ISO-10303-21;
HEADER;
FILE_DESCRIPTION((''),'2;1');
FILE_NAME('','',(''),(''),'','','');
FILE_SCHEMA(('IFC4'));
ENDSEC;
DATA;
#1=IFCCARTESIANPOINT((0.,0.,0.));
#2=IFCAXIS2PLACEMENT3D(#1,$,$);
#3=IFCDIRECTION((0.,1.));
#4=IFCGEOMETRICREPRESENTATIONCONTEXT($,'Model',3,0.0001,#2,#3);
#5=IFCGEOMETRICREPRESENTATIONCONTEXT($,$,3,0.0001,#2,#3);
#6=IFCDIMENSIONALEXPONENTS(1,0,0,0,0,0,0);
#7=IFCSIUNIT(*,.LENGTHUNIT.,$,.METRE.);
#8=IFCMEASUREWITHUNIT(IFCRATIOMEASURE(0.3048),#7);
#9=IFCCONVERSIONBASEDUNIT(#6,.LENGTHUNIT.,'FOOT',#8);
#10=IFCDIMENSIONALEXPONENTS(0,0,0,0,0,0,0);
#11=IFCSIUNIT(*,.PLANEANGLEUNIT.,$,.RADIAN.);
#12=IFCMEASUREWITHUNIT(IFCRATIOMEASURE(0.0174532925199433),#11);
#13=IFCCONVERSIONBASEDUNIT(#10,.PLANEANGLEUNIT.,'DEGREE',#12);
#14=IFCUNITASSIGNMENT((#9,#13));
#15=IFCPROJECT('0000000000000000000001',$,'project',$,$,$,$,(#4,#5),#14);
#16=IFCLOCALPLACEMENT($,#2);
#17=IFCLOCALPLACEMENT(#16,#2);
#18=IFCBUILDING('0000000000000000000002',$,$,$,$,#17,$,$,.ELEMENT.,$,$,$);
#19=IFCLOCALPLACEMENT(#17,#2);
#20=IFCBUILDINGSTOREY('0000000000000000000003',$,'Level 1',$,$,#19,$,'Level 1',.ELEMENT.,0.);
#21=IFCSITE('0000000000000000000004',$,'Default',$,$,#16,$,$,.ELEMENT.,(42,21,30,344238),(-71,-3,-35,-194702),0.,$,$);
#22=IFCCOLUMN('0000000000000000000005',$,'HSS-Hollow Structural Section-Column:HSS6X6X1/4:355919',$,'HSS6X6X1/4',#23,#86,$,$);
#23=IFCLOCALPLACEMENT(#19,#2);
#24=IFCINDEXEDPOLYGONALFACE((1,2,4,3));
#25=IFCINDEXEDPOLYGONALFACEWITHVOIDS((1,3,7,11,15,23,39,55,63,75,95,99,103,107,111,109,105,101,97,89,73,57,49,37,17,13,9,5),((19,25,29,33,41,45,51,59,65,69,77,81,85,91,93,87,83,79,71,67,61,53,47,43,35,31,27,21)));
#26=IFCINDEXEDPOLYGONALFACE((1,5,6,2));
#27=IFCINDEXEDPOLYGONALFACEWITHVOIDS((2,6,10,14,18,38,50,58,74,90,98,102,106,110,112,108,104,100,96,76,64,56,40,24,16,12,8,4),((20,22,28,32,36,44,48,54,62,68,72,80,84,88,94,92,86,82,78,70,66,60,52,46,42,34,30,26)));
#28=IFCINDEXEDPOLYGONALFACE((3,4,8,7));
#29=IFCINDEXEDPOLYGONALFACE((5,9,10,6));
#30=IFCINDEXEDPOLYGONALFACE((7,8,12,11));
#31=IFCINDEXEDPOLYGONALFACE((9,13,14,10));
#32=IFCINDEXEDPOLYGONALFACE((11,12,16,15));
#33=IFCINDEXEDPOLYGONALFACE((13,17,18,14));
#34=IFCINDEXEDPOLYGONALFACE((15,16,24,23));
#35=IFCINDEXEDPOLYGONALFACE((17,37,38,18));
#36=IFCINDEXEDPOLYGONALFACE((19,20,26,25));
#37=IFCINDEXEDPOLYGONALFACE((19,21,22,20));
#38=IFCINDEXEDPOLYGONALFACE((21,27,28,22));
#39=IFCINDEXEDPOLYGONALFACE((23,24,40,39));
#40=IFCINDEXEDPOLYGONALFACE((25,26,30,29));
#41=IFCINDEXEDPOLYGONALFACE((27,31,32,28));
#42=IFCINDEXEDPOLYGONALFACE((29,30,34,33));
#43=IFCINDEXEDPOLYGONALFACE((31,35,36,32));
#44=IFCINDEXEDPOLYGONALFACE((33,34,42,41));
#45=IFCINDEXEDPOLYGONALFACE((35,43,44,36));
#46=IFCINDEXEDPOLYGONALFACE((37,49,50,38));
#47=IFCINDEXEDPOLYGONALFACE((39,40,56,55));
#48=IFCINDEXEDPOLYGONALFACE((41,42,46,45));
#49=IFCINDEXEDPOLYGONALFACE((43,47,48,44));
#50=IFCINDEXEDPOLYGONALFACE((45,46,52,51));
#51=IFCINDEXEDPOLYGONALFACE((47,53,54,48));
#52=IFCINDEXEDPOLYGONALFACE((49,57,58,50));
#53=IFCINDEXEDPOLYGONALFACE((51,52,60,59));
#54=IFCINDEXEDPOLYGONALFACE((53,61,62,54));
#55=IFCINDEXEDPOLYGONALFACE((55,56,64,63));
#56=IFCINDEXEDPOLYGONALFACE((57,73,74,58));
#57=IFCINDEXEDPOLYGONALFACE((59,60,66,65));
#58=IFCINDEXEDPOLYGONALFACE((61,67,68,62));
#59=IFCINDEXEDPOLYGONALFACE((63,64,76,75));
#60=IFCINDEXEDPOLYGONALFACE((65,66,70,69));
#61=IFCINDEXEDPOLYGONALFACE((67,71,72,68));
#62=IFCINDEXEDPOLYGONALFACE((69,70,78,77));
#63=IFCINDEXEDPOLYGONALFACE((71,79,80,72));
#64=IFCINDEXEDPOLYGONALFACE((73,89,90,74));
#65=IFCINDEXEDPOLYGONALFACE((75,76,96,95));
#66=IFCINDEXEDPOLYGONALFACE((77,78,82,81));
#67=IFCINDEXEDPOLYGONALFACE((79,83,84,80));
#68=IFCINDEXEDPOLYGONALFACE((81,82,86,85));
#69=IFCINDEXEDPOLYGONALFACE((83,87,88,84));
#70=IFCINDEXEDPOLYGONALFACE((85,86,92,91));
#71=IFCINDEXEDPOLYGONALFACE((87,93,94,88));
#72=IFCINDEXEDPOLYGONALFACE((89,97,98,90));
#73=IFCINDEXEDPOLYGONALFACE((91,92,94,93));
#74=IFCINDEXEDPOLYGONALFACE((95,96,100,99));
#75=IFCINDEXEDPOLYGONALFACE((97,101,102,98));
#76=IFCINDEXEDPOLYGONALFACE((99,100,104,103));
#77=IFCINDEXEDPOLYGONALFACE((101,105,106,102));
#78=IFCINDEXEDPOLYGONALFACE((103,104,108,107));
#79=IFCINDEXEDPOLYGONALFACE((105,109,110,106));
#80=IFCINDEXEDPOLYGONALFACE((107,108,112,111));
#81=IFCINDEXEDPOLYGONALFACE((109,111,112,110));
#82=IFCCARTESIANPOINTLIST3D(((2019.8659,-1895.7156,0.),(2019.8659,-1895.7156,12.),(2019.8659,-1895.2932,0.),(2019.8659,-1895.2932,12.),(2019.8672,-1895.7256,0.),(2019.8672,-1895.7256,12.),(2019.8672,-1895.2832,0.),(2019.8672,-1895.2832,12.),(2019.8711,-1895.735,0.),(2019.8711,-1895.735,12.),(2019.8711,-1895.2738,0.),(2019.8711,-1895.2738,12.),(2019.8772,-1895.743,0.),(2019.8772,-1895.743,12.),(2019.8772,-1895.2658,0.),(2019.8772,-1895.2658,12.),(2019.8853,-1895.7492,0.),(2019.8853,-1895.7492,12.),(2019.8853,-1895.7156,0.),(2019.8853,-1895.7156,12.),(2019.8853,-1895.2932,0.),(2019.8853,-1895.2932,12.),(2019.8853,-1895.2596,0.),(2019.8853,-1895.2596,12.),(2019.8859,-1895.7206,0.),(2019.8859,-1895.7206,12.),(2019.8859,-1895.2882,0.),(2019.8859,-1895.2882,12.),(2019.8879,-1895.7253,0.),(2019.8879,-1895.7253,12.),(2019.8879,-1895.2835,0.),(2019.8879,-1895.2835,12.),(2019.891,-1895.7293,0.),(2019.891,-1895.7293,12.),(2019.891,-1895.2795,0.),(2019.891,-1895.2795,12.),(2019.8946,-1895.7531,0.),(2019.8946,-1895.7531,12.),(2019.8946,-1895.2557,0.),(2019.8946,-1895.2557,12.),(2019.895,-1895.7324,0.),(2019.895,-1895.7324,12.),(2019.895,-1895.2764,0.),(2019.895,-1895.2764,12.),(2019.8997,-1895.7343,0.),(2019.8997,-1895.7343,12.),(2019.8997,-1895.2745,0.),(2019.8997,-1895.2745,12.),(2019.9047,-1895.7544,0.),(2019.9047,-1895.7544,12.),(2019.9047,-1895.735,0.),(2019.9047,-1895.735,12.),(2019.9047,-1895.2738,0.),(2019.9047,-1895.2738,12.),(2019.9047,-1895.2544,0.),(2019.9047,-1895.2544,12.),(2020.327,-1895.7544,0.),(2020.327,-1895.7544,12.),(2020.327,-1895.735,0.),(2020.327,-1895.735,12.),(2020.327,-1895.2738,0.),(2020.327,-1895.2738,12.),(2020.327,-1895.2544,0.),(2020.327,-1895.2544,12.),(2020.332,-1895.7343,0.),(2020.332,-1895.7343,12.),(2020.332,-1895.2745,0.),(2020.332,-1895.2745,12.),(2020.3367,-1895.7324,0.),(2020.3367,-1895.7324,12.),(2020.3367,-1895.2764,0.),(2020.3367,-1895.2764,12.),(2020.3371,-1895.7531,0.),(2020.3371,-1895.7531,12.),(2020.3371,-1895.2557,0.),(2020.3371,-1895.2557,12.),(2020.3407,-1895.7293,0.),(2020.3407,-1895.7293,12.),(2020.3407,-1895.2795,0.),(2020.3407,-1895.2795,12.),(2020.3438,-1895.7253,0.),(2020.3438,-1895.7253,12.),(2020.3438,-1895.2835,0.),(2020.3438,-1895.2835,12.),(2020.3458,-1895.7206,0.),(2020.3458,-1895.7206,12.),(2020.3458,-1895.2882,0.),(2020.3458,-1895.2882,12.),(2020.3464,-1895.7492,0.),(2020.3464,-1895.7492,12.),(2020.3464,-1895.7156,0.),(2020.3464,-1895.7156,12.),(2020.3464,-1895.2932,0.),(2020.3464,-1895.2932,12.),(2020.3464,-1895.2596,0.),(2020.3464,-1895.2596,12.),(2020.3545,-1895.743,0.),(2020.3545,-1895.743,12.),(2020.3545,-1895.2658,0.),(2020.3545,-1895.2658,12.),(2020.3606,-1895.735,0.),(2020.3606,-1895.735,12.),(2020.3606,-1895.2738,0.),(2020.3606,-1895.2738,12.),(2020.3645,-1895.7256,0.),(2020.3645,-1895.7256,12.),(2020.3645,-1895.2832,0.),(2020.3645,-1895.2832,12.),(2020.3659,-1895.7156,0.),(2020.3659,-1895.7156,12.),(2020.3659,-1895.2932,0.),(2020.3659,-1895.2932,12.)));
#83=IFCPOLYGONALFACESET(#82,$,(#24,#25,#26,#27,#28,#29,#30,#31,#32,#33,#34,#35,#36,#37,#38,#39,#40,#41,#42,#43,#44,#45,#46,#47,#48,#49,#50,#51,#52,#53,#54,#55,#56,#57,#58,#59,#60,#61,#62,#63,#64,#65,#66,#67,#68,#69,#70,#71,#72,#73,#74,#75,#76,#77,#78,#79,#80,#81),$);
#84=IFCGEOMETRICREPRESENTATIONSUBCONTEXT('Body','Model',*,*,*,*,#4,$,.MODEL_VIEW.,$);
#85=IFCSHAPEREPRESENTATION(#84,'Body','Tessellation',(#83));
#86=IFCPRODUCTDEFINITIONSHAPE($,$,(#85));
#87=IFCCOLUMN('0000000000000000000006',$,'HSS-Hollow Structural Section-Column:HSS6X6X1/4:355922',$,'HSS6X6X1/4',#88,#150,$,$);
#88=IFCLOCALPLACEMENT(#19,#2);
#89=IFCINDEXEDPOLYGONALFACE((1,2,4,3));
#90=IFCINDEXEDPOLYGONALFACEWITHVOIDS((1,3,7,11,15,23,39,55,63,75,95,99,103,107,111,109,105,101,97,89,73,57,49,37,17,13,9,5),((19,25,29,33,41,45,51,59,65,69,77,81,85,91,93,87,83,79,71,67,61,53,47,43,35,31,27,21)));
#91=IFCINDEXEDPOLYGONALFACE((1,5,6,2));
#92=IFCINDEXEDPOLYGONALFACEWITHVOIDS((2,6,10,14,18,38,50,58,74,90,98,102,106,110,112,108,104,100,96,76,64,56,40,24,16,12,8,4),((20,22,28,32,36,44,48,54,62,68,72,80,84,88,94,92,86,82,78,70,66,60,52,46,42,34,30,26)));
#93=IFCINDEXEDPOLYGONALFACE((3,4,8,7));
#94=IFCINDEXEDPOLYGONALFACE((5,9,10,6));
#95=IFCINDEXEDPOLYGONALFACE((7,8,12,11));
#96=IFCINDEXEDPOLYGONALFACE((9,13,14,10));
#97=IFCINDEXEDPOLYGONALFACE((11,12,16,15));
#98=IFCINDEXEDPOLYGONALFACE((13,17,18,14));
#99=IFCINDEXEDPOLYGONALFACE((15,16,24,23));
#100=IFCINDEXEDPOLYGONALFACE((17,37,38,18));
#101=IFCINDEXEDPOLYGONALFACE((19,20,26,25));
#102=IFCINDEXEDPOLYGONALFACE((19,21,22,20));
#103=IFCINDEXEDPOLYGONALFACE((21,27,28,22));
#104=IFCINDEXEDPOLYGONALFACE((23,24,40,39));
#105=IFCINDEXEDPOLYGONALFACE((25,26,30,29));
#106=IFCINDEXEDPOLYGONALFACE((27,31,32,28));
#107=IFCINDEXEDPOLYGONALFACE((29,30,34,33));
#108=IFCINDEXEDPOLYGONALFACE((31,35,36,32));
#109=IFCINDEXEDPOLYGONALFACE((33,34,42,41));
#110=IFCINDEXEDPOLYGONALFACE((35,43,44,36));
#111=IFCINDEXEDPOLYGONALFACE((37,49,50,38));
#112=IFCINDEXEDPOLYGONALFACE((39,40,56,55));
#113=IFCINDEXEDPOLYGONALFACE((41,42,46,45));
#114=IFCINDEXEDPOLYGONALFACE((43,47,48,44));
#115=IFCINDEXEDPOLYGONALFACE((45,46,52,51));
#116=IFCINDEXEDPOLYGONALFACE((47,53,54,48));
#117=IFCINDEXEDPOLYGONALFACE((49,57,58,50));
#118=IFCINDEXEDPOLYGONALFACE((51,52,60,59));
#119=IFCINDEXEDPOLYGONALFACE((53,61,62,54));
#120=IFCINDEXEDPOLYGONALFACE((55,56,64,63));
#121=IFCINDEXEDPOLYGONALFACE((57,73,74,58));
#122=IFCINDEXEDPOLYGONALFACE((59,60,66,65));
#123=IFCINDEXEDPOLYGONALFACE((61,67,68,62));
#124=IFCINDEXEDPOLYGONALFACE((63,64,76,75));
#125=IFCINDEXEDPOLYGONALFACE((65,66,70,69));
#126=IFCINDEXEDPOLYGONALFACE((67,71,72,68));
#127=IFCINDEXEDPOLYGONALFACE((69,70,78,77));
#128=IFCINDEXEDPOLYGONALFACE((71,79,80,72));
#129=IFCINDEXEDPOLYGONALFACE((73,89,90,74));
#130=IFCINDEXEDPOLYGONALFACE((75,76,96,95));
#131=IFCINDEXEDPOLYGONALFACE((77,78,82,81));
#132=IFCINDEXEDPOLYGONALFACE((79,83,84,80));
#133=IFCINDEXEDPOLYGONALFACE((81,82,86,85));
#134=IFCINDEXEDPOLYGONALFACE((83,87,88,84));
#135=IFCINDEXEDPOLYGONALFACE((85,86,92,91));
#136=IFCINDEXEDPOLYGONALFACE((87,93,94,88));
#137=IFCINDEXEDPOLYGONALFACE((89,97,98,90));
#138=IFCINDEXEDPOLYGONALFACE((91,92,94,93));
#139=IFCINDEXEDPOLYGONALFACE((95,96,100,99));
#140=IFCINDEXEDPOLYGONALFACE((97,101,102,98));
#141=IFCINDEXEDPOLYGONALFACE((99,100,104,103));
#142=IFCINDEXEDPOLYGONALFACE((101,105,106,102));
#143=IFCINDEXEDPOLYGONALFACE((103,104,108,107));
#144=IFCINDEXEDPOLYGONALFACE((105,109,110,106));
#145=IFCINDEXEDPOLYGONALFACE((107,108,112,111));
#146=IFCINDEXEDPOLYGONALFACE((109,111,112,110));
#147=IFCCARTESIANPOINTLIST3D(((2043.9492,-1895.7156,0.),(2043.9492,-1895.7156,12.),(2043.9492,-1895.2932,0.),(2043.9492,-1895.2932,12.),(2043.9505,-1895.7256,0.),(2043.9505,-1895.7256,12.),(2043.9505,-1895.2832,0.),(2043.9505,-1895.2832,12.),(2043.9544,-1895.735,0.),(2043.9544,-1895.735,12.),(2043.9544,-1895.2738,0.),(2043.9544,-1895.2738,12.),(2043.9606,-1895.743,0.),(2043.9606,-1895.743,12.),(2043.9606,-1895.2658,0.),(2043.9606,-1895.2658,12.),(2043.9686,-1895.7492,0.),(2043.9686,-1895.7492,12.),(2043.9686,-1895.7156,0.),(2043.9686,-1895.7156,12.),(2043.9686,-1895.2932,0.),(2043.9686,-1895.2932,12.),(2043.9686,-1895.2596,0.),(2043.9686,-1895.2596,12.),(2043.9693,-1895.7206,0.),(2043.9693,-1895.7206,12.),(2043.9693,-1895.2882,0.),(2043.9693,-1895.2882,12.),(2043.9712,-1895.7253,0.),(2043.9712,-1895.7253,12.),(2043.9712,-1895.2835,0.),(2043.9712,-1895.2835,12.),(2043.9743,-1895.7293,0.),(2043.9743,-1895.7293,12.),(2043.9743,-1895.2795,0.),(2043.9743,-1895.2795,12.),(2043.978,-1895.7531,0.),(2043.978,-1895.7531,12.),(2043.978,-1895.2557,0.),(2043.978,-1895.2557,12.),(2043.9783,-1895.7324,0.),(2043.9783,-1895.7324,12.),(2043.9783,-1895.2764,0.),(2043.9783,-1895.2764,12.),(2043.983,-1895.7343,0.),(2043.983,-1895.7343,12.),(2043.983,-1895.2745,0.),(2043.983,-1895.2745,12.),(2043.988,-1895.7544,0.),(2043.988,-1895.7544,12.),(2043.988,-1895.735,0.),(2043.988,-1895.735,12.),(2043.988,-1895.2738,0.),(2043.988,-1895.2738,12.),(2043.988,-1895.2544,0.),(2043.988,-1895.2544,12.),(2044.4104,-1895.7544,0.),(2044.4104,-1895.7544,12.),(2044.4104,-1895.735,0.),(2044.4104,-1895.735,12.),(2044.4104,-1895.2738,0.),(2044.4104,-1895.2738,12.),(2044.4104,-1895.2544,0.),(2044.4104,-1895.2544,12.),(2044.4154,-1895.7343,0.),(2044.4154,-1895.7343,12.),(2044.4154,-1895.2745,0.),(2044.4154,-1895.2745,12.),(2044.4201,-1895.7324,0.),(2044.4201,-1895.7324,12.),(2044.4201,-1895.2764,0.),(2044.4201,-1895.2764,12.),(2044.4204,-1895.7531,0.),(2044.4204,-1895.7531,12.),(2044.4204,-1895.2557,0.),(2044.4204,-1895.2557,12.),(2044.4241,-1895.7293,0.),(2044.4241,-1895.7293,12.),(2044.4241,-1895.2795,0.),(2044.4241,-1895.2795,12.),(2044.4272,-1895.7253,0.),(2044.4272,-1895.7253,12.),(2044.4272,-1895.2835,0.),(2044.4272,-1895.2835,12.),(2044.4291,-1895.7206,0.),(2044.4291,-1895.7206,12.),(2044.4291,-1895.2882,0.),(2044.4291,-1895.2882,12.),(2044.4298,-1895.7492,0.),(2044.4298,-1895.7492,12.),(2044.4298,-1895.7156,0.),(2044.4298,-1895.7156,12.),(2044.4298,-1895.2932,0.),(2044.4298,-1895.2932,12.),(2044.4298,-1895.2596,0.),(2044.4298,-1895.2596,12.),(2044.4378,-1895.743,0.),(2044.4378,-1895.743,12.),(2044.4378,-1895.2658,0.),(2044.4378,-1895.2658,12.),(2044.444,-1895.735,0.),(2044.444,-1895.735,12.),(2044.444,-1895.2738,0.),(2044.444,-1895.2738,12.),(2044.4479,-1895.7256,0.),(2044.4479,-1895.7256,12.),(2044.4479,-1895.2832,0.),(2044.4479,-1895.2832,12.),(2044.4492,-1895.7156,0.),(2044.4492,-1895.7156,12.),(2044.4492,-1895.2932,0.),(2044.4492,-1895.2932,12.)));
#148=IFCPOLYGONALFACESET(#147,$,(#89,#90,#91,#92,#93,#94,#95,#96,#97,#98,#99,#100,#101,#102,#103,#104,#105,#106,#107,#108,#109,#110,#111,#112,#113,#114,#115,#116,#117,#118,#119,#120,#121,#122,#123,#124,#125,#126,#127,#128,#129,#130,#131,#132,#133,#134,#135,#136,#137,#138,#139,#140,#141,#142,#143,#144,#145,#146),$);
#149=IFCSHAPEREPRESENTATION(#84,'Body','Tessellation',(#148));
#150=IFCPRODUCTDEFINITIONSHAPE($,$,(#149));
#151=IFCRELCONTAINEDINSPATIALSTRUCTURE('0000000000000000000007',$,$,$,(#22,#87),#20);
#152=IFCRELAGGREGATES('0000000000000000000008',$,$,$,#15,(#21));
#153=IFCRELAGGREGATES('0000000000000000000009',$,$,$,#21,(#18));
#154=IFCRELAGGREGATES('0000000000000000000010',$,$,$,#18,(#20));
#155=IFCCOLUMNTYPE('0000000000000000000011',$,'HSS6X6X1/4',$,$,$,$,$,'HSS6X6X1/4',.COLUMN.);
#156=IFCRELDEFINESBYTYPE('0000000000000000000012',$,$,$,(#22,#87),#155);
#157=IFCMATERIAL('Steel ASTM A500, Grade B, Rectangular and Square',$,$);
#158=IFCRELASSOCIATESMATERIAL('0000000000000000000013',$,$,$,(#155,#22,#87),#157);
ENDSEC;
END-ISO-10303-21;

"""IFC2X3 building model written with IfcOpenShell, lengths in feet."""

from ifc_helpers import new_model, entity, si_unit, converted_unit, direction, frame, frame_2d, origin, place, context, subcontext, project, spatial, polyline, circle_curve, parameter, trimmed, segment, composite_curve, outline, extrude, source, transform, mapped, material, type_object, type_shapes, element, save


model = new_model("IFC2X3")

# Units and contexts
model_context = context("Model", 3, precision=0.0001, world=origin(), true_north=direction((0.0, 1.0)))
context_of_model = context(None, 3, precision=0.0001, world=origin(), true_north=direction((0.0, 1.0)))
body_context = subcontext(model_context, "Body", "Model", "MODEL_VIEW")
ifc_project = project(units=[converted_unit("LENGTHUNIT", "FOOT", entity("IfcRatioMeasure", 0.3048), si_unit("LENGTHUNIT", "METRE"), dimensions=[1, 0, 0, 0, 0, 0, 0]), converted_unit("PLANEANGLEUNIT", "DEGREE", entity("IfcRatioMeasure", 0.0174532925199433), si_unit("PLANEANGLEUNIT", "RADIAN"), dimensions=[0, 0, 0, 0, 0, 0, 0])], contexts=[model_context, context_of_model])

# Site, building, storey
site_placement = place(None, origin())
site = spatial("IfcSite", under=ifc_project, at=site_placement, Name="Default", CompositionType="ELEMENT", RefLatitude=(42, 21, 30, 344238), RefLongitude=(-71, -3, -35, -194702), RefElevation=0.0)
building_placement = place(site_placement, origin())
building = spatial("IfcBuilding", under=site, at=building_placement, CompositionType="ELEMENT")
storey_placement = place(building_placement, origin())
storey = spatial("IfcBuildingStorey", under=building, at=storey_placement, Name="Level 1", LongName="Level 1", CompositionType="ELEMENT", Elevation=0.0)

# Columns
ifc_material_1 = material(Name="Steel ASTM A500, Grade B, Rectangular and Square")
column_type = type_object("IfcColumnType", Name="HSS6X6X1/4", ElementType="HSS6X6X1/4", PredefinedType="COLUMN", material=ifc_material_1)
shared_shape = source(origin(), body_context, "Body", "SweptSolid", [
    extrude(outline(composite_curve([segment(polyline([(-0.2112, -0.25), (0.2112, -0.25)]), True, "CONTINUOUS"), segment(trimmed(circle_curve(frame_2d((0.2112, -0.2112), x_axis=(-1.0, 0.0)), 0.0388), [parameter(90.0)], [parameter(180.0)], True, "PARAMETER"), True, "CONTINUOUS"), segment(polyline([(0.25, -0.2112), (0.25, 0.2112)]), True, "CONTINUOUS"), segment(trimmed(circle_curve(frame_2d((0.2112, 0.2112), x_axis=(-1.0, 0.0)), 0.0388), [parameter(180.0)], [parameter(270.0)], True, "PARAMETER"), True, "CONTINUOUS"), segment(polyline([(0.2112, 0.25), (-0.2112, 0.25)]), True, "CONTINUOUS"), segment(trimmed(circle_curve(frame_2d((-0.2112, 0.2112), x_axis=(-1.0, 0.0)), 0.0388), [parameter(270.0)], [parameter(360.0)], True, "PARAMETER"), True, "CONTINUOUS"), segment(polyline([(-0.25, 0.2112), (-0.25, -0.2112)]), True, "CONTINUOUS"), segment(trimmed(circle_curve(frame_2d((-0.2112, -0.2112), x_axis=(-1.0, 0.0)), 0.0388), [parameter(360.0)], [parameter(90.0)], True, "PARAMETER"), True, "CONTINUOUS")], self_intersect=False), holes=[composite_curve([segment(trimmed(circle_curve(frame_2d((-0.2112, -0.2112), x_axis=(-1.0, 0.0)), 0.0194), [parameter(0.0)], [parameter(90.0)], True, "PARAMETER"), False, "CONTINUOUS"), segment(polyline([(-0.2306, -0.2112), (-0.2306, 0.2112)]), True, "CONTINUOUS"), segment(trimmed(circle_curve(frame_2d((-0.2112, 0.2112), x_axis=(-1.0, 0.0)), 0.0194), [parameter(270.0)], [parameter(360.0)], True, "PARAMETER"), False, "CONTINUOUS"), segment(polyline([(-0.2112, 0.2306), (0.2112, 0.2306)]), True, "CONTINUOUS"), segment(trimmed(circle_curve(frame_2d((0.2112, 0.2112), x_axis=(-1.0, 0.0)), 0.0194), [parameter(180.0)], [parameter(270.0)], True, "PARAMETER"), False, "CONTINUOUS"), segment(polyline([(0.2306, 0.2112), (0.2306, -0.2112)]), True, "CONTINUOUS"), segment(trimmed(circle_curve(frame_2d((0.2112, -0.2112), x_axis=(-1.0, 0.0)), 0.0194), [parameter(90.0)], [parameter(180.0)], True, "PARAMETER"), False, "CONTINUOUS"), segment(polyline([(0.2112, -0.2306), (-0.2112, -0.2306)]), True, "CONTINUOUS")], self_intersect=False)]), frame((0.0, 0.0, 0.0), z_axis=(0.0, 0.0, 1.0), x_axis=(-1.0, 0.0, 0.0)), (0.0, 0.0, 1.0), 12.0),
])
type_shapes(column_type, [shared_shape])
for number, where, z_axis, x_axis, name in (
    (1, (2020.1159, -1895.5044, 0.0), (0.0, 0.0, 1.0), (-1.0, 0.0, 0.0), "HSS-Hollow Structural Section-Column:HSS6X6X1/4:355919"),
    (2, (2044.1992, -1895.5044, 0.0), (0.0, 0.0, 1.0), (-1.0, 0.0, 0.0), "HSS-Hollow Structural Section-Column:HSS6X6X1/4:355922"),
):
    element("IfcColumn", number, at=place(storey_placement, frame(where, z_axis=z_axis, x_axis=x_axis)), inside=storey, type_object=column_type, material=ifc_material_1, Name=name, ObjectType="HSS6X6X1/4", context=body_context, shape_type="MappedRepresentation", body=[
        mapped(shared_shape, transform((0.0, 0.0, 0.0), scale=1.0)),
    ])

save(model, "model.ifc")
